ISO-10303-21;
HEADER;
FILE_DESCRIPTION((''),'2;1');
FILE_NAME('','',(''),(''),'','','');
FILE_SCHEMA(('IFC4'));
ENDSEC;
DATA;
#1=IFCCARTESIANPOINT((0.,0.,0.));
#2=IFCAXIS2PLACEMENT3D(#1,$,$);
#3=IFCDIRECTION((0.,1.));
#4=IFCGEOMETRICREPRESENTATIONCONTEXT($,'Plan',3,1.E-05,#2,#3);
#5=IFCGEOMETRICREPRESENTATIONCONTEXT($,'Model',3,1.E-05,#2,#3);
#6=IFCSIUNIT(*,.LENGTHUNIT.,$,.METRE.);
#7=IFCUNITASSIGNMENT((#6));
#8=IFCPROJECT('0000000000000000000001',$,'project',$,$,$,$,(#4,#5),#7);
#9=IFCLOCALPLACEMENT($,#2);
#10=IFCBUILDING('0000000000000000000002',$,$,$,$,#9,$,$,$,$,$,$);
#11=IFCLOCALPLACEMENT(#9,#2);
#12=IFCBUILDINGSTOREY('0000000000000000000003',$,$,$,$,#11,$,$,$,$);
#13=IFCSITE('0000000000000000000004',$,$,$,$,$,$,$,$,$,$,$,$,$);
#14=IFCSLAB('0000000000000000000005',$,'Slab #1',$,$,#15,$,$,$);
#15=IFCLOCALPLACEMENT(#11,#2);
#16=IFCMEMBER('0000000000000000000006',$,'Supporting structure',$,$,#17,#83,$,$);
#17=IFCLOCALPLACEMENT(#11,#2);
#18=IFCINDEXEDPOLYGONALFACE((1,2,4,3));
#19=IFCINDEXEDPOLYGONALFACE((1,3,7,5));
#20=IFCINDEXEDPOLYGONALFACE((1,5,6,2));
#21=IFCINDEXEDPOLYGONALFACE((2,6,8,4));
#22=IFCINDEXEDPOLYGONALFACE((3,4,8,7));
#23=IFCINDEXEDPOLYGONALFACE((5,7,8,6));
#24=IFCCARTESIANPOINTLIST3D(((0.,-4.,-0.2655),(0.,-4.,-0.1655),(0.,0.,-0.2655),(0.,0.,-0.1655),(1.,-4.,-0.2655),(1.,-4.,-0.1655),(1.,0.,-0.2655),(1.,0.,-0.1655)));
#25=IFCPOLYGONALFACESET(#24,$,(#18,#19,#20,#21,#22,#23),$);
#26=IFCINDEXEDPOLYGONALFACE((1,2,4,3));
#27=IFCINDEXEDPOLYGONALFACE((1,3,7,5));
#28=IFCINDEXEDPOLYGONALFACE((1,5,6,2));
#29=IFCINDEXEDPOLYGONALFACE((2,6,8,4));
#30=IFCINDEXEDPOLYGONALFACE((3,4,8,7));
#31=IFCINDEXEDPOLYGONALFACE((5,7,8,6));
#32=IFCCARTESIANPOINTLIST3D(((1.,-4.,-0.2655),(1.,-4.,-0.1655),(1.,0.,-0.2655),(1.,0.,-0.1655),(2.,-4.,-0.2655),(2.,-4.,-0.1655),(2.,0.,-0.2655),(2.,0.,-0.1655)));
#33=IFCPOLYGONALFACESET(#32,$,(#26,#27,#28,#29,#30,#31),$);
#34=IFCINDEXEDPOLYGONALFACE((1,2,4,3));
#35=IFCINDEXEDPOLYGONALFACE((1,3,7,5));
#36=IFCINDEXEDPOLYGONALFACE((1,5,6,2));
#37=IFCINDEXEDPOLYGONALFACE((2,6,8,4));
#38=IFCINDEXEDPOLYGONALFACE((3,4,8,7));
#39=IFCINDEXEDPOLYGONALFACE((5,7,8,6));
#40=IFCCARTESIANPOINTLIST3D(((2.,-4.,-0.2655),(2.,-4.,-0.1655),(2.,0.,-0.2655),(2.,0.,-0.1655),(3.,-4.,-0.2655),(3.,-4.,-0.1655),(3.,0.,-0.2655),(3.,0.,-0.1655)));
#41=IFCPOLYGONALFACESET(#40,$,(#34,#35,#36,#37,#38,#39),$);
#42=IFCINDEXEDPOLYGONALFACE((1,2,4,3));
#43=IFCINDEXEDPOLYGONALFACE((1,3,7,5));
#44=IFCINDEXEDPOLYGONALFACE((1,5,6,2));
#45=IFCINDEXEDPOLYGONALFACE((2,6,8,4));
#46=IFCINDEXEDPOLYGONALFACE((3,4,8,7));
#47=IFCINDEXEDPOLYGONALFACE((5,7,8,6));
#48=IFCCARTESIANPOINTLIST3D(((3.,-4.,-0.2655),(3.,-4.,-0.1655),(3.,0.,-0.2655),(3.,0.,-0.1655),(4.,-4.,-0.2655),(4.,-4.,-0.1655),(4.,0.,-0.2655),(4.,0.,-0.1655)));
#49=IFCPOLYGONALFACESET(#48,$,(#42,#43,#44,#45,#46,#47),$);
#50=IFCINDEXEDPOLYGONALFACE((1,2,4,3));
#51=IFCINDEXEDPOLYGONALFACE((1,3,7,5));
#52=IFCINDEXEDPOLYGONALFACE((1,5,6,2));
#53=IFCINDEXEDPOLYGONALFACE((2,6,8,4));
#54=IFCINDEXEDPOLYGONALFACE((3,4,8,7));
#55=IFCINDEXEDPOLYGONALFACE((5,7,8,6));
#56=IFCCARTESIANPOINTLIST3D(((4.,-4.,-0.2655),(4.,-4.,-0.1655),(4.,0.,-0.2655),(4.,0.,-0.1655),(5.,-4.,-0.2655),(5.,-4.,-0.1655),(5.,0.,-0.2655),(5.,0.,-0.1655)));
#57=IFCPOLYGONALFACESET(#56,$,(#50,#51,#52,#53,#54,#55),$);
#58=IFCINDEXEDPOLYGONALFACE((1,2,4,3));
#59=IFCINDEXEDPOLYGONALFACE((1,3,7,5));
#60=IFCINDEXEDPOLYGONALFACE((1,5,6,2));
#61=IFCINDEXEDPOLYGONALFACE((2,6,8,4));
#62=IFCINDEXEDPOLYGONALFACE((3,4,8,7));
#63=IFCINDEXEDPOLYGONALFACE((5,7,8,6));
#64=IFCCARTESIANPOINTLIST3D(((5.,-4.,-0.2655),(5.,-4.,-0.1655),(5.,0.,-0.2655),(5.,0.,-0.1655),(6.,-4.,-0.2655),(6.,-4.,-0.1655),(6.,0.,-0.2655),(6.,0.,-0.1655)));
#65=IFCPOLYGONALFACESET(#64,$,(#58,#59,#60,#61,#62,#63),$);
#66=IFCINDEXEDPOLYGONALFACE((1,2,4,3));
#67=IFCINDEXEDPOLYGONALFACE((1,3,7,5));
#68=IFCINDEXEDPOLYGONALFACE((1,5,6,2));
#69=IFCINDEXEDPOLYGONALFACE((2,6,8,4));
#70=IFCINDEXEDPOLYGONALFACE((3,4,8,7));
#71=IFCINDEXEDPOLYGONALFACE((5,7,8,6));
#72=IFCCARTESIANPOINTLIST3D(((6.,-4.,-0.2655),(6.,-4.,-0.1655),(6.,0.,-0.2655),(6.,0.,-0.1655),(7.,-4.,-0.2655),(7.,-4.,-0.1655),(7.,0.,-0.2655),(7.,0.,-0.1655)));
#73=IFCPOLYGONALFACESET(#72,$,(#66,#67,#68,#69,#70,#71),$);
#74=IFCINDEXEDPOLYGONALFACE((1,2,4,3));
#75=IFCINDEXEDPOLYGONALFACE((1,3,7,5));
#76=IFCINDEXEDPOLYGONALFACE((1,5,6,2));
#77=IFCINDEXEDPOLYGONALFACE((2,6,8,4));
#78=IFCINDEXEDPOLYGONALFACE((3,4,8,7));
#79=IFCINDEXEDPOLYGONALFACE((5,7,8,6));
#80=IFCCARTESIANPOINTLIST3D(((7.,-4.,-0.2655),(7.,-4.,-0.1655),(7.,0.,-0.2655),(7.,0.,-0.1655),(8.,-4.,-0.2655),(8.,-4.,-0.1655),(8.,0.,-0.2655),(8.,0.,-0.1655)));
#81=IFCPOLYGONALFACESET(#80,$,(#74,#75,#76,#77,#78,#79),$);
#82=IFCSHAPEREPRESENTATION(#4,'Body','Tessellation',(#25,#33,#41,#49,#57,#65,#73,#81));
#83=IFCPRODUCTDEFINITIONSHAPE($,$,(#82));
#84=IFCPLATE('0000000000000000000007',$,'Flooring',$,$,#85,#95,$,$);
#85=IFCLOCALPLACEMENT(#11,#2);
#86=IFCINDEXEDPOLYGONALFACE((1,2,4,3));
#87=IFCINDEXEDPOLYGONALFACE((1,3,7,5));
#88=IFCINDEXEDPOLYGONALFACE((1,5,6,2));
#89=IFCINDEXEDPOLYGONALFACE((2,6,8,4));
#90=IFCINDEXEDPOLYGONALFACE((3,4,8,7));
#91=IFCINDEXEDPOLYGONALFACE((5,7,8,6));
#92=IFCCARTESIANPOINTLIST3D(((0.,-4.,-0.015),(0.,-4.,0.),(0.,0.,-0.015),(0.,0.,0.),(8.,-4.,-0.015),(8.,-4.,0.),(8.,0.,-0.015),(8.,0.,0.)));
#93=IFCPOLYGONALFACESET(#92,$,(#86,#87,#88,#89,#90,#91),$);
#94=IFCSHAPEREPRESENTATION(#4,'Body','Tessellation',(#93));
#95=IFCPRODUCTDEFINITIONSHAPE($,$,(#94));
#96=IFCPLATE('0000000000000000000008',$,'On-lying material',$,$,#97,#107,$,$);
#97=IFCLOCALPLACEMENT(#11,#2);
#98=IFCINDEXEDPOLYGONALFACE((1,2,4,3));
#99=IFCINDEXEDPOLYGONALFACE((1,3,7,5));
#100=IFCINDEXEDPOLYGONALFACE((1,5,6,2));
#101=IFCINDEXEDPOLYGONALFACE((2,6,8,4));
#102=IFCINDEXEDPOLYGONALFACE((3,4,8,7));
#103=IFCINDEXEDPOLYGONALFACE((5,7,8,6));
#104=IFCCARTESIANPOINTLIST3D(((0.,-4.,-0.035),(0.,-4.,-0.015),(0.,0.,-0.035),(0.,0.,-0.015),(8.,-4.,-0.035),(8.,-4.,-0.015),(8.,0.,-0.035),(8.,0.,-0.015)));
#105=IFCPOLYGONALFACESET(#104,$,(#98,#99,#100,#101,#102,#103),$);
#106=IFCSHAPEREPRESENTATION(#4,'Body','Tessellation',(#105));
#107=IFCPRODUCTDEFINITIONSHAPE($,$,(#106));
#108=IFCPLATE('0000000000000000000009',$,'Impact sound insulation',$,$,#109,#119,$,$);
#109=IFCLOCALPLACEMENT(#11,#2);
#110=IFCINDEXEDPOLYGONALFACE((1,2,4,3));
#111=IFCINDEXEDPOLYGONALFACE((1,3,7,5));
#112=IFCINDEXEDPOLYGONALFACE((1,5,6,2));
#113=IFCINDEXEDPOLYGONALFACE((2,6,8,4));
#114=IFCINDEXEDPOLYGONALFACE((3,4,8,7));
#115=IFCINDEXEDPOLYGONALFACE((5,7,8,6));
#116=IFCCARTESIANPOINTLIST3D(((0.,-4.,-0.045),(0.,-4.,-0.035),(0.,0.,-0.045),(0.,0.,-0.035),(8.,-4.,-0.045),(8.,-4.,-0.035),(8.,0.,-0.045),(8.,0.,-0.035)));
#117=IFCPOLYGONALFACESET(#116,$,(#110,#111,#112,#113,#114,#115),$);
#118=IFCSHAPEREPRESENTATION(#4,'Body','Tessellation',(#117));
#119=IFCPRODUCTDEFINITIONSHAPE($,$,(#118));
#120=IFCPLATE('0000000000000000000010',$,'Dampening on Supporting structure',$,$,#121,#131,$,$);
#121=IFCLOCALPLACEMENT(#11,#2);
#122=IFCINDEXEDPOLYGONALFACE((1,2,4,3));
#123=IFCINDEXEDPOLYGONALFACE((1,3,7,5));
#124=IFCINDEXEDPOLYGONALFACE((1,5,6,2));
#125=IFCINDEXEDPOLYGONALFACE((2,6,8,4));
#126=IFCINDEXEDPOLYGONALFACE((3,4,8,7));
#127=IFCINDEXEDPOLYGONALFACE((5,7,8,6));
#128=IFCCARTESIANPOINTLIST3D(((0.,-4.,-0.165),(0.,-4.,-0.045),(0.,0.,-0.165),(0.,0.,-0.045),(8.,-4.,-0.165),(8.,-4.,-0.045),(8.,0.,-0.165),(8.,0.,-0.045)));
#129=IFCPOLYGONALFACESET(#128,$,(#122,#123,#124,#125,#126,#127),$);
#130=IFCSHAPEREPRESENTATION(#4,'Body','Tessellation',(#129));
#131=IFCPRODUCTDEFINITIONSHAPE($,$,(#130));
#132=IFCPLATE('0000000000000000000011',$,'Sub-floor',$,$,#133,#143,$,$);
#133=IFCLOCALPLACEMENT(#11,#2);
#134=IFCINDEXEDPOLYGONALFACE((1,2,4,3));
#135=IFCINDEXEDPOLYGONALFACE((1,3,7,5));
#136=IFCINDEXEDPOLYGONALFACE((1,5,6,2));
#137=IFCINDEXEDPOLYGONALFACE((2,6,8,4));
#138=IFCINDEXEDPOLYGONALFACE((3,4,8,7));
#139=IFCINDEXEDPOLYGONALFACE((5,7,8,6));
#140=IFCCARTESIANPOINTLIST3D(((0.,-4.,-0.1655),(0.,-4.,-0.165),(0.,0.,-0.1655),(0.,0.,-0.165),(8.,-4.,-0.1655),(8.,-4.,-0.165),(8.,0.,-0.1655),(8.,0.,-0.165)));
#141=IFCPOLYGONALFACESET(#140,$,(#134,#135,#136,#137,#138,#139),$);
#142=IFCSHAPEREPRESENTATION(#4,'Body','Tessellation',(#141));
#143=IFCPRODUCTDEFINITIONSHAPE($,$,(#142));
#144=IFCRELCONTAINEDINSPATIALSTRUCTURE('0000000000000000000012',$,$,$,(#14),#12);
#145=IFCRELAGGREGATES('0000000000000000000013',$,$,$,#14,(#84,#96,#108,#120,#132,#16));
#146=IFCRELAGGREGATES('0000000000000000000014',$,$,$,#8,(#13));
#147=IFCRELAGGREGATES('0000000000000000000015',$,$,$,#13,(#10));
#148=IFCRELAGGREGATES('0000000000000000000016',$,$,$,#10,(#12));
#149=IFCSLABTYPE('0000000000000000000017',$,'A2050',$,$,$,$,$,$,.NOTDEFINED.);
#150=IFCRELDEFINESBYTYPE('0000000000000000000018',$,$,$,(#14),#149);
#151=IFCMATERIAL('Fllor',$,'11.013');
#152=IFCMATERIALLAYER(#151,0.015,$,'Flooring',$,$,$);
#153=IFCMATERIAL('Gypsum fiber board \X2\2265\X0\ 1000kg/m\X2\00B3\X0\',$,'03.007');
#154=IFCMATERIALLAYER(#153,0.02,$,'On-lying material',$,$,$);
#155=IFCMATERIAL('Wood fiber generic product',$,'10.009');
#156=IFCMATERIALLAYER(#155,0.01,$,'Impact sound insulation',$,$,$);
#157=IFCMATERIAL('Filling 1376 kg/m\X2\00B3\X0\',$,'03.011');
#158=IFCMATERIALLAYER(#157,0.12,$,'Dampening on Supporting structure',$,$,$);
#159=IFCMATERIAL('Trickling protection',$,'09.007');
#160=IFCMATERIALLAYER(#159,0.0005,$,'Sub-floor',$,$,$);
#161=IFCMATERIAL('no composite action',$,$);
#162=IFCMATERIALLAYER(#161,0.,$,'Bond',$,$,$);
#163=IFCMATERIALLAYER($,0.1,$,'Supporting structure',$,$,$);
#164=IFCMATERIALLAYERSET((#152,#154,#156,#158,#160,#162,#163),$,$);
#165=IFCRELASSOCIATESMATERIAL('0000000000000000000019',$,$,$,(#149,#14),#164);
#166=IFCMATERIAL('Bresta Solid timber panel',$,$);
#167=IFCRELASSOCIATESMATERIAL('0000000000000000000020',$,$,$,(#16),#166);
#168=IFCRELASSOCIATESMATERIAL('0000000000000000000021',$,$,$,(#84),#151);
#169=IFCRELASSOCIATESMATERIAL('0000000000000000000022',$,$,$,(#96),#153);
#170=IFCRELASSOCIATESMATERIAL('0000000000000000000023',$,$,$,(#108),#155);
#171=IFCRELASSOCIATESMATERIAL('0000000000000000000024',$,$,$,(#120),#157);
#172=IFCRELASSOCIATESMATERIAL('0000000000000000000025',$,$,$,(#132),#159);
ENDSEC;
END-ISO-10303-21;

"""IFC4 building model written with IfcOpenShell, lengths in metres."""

from ifc_helpers import new_model, si_unit, direction, frame, frame_2d, origin, origin_with_axes, place, context, project, spatial, rectangle, extrude, material, layer, layer_set, type_object, element, aggregate, save


model = new_model("IFC4")

# Units and contexts
plan_context = context("Plan", 3, precision=1e-05, world=origin(), true_north=direction((0.0, 1.0)))
model_context = context("Model", 3, precision=1e-05, world=origin(), true_north=direction((0.0, 1.0)))
ifc_project = project(units=[si_unit("LENGTHUNIT", "METRE")], contexts=[plan_context, model_context])

# Site, building, storey
site = spatial("IfcSite", under=ifc_project)
building_placement = place(None, origin())
building = spatial("IfcBuilding", under=site, at=building_placement)
storey_placement = place(building_placement, origin())
storey = spatial("IfcBuildingStorey", under=building, at=storey_placement)

# Slab, member, plates
ifc_material_1 = material(Name="Fllor", Category="11.013")
ifc_layer_1 = layer(ifc_material_1, 0.015, Name="Flooring")
ifc_material_2 = material(Name="Gypsum fiber board ≥ 1000kg/m³", Category="03.007")
ifc_layer_2 = layer(ifc_material_2, 0.02, Name="On-lying material")
ifc_material_3 = material(Name="Wood fiber generic product", Category="10.009")
ifc_layer_3 = layer(ifc_material_3, 0.01, Name="Impact sound insulation")
ifc_material_4 = material(Name="Filling 1376 kg/m³", Category="03.011")
ifc_layer_4 = layer(ifc_material_4, 0.12, Name="Dampening on Supporting structure")
ifc_material_5 = material(Name="Trickling protection", Category="09.007")
ifc_layer_5 = layer(ifc_material_5, 0.0005, Name="Sub-floor")
ifc_material_6 = material(Name="no composite action")
ifc_layer_6 = layer(ifc_material_6, 0.0, Name="Bond")
ifc_layer_7 = layer(None, 0.1, Name="Supporting structure")
ifc_layer_set = layer_set([ifc_layer_1, ifc_layer_2, ifc_layer_3, ifc_layer_4, ifc_layer_5, ifc_layer_6, ifc_layer_7])
slab_type = type_object("IfcSlabType", Name="A2050", PredefinedType="NOTDEFINED", material=ifc_layer_set)
slab_placement = place(None, frame((0.0, 0.0, 0.0), z_axis=(0.0, 0.0, -1.0), x_axis=(1.0, 0.0, 0.0)))
slab = element("IfcSlab", 1, at=slab_placement, inside=storey, type_object=slab_type, material=ifc_layer_set, Name="Slab #1")
ifc_material_7 = material(Name="Bresta Solid timber panel")
member_placement = place(slab_placement, origin())
member = element("IfcMember", 2, at=member_placement, material=ifc_material_7, Name="Supporting structure", context=plan_context, shape_type="SweptSolid", body=[
    extrude(rectangle(XDim=1.0, YDim=0.1, at=frame_2d((0.5, 0.05), x_axis=(1.0, 0.0))), frame((0.0, 4.0, 0.1655), z_axis=(0.0, -1.0, 0.0), x_axis=(1.0, 0.0, 0.0)), (0.0, 0.0, 1.0), 4.0),
    extrude(rectangle(XDim=1.0, YDim=0.1, at=frame_2d((0.5, 0.05), x_axis=(1.0, 0.0))), frame((1.0, 4.0, 0.1655), z_axis=(0.0, -1.0, 0.0), x_axis=(1.0, 0.0, 0.0)), (0.0, 0.0, 1.0), 4.0),
    extrude(rectangle(XDim=1.0, YDim=0.1, at=frame_2d((0.5, 0.05), x_axis=(1.0, 0.0))), frame((2.0, 4.0, 0.1655), z_axis=(0.0, -1.0, 0.0), x_axis=(1.0, 0.0, 0.0)), (0.0, 0.0, 1.0), 4.0),
    extrude(rectangle(XDim=1.0, YDim=0.1, at=frame_2d((0.5, 0.05), x_axis=(1.0, 0.0))), frame((3.0, 4.0, 0.1655), z_axis=(0.0, -1.0, 0.0), x_axis=(1.0, 0.0, 0.0)), (0.0, 0.0, 1.0), 4.0),
    extrude(rectangle(XDim=1.0, YDim=0.1, at=frame_2d((0.5, 0.05), x_axis=(1.0, 0.0))), frame((4.0, 4.0, 0.1655), z_axis=(0.0, -1.0, 0.0), x_axis=(1.0, 0.0, 0.0)), (0.0, 0.0, 1.0), 4.0),
    extrude(rectangle(XDim=1.0, YDim=0.1, at=frame_2d((0.5, 0.05), x_axis=(1.0, 0.0))), frame((5.0, 4.0, 0.1655), z_axis=(0.0, -1.0, 0.0), x_axis=(1.0, 0.0, 0.0)), (0.0, 0.0, 1.0), 4.0),
    extrude(rectangle(XDim=1.0, YDim=0.1, at=frame_2d((0.5, 0.05), x_axis=(1.0, 0.0))), frame((6.0, 4.0, 0.1655), z_axis=(0.0, -1.0, 0.0), x_axis=(1.0, 0.0, 0.0)), (0.0, 0.0, 1.0), 4.0),
    extrude(rectangle(XDim=1.0, YDim=0.1, at=frame_2d((0.5, 0.05), x_axis=(1.0, 0.0))), frame((7.0, 4.0, 0.1655), z_axis=(0.0, -1.0, 0.0), x_axis=(1.0, 0.0, 0.0)), (0.0, 0.0, 1.0), 4.0),
])
plate_1_placement = place(slab_placement, origin())
plate_1 = element("IfcPlate", 3, at=plate_1_placement, material=ifc_material_1, Name="Flooring", context=plan_context, shape_type="SweptSolid", body=[
    extrude(rectangle(XDim=8.0, YDim=4.0, at=frame_2d((4.0, 2.0), x_axis=(1.0, 0.0))), origin_with_axes(), (0.0, 0.0, 1.0), 0.015),
])
plate_2_placement = place(slab_placement, origin())
plate_2 = element("IfcPlate", 4, at=plate_2_placement, material=ifc_material_2, Name="On-lying material", context=plan_context, shape_type="SweptSolid", body=[
    extrude(rectangle(XDim=8.0, YDim=4.0, at=frame_2d((4.0, 2.0), x_axis=(1.0, 0.0))), frame((0.0, 0.0, 0.015), z_axis=(0.0, 0.0, 1.0), x_axis=(1.0, 0.0, 0.0)), (0.0, 0.0, 1.0), 0.02),
])
plate_3_placement = place(slab_placement, origin())
plate_3 = element("IfcPlate", 5, at=plate_3_placement, material=ifc_material_3, Name="Impact sound insulation", context=plan_context, shape_type="SweptSolid", body=[
    extrude(rectangle(XDim=8.0, YDim=4.0, at=frame_2d((4.0, 2.0), x_axis=(1.0, 0.0))), frame((0.0, 0.0, 0.035), z_axis=(0.0, 0.0, 1.0), x_axis=(1.0, 0.0, 0.0)), (0.0, 0.0, 1.0), 0.01),
])
plate_4_placement = place(slab_placement, origin())
plate_4 = element("IfcPlate", 6, at=plate_4_placement, material=ifc_material_4, Name="Dampening on Supporting structure", context=plan_context, shape_type="SweptSolid", body=[
    extrude(rectangle(XDim=8.0, YDim=4.0, at=frame_2d((4.0, 2.0), x_axis=(1.0, 0.0))), frame((0.0, 0.0, 0.045), z_axis=(0.0, 0.0, 1.0), x_axis=(1.0, 0.0, 0.0)), (0.0, 0.0, 1.0), 0.12),
])
plate_5_placement = place(slab_placement, origin())
plate_5 = element("IfcPlate", 7, at=plate_5_placement, material=ifc_material_5, Name="Sub-floor", context=plan_context, shape_type="SweptSolid", body=[
    extrude(rectangle(XDim=8.0, YDim=4.0, at=frame_2d((4.0, 2.0), x_axis=(1.0, 0.0))), frame((0.0, 0.0, 0.165), z_axis=(0.0, 0.0, 1.0), x_axis=(1.0, 0.0, 0.0)), (0.0, 0.0, 1.0), 0.0005),
])
aggregate(slab, [plate_1, plate_2, plate_3, plate_4, plate_5, member])

save(model, "model.ifc")
